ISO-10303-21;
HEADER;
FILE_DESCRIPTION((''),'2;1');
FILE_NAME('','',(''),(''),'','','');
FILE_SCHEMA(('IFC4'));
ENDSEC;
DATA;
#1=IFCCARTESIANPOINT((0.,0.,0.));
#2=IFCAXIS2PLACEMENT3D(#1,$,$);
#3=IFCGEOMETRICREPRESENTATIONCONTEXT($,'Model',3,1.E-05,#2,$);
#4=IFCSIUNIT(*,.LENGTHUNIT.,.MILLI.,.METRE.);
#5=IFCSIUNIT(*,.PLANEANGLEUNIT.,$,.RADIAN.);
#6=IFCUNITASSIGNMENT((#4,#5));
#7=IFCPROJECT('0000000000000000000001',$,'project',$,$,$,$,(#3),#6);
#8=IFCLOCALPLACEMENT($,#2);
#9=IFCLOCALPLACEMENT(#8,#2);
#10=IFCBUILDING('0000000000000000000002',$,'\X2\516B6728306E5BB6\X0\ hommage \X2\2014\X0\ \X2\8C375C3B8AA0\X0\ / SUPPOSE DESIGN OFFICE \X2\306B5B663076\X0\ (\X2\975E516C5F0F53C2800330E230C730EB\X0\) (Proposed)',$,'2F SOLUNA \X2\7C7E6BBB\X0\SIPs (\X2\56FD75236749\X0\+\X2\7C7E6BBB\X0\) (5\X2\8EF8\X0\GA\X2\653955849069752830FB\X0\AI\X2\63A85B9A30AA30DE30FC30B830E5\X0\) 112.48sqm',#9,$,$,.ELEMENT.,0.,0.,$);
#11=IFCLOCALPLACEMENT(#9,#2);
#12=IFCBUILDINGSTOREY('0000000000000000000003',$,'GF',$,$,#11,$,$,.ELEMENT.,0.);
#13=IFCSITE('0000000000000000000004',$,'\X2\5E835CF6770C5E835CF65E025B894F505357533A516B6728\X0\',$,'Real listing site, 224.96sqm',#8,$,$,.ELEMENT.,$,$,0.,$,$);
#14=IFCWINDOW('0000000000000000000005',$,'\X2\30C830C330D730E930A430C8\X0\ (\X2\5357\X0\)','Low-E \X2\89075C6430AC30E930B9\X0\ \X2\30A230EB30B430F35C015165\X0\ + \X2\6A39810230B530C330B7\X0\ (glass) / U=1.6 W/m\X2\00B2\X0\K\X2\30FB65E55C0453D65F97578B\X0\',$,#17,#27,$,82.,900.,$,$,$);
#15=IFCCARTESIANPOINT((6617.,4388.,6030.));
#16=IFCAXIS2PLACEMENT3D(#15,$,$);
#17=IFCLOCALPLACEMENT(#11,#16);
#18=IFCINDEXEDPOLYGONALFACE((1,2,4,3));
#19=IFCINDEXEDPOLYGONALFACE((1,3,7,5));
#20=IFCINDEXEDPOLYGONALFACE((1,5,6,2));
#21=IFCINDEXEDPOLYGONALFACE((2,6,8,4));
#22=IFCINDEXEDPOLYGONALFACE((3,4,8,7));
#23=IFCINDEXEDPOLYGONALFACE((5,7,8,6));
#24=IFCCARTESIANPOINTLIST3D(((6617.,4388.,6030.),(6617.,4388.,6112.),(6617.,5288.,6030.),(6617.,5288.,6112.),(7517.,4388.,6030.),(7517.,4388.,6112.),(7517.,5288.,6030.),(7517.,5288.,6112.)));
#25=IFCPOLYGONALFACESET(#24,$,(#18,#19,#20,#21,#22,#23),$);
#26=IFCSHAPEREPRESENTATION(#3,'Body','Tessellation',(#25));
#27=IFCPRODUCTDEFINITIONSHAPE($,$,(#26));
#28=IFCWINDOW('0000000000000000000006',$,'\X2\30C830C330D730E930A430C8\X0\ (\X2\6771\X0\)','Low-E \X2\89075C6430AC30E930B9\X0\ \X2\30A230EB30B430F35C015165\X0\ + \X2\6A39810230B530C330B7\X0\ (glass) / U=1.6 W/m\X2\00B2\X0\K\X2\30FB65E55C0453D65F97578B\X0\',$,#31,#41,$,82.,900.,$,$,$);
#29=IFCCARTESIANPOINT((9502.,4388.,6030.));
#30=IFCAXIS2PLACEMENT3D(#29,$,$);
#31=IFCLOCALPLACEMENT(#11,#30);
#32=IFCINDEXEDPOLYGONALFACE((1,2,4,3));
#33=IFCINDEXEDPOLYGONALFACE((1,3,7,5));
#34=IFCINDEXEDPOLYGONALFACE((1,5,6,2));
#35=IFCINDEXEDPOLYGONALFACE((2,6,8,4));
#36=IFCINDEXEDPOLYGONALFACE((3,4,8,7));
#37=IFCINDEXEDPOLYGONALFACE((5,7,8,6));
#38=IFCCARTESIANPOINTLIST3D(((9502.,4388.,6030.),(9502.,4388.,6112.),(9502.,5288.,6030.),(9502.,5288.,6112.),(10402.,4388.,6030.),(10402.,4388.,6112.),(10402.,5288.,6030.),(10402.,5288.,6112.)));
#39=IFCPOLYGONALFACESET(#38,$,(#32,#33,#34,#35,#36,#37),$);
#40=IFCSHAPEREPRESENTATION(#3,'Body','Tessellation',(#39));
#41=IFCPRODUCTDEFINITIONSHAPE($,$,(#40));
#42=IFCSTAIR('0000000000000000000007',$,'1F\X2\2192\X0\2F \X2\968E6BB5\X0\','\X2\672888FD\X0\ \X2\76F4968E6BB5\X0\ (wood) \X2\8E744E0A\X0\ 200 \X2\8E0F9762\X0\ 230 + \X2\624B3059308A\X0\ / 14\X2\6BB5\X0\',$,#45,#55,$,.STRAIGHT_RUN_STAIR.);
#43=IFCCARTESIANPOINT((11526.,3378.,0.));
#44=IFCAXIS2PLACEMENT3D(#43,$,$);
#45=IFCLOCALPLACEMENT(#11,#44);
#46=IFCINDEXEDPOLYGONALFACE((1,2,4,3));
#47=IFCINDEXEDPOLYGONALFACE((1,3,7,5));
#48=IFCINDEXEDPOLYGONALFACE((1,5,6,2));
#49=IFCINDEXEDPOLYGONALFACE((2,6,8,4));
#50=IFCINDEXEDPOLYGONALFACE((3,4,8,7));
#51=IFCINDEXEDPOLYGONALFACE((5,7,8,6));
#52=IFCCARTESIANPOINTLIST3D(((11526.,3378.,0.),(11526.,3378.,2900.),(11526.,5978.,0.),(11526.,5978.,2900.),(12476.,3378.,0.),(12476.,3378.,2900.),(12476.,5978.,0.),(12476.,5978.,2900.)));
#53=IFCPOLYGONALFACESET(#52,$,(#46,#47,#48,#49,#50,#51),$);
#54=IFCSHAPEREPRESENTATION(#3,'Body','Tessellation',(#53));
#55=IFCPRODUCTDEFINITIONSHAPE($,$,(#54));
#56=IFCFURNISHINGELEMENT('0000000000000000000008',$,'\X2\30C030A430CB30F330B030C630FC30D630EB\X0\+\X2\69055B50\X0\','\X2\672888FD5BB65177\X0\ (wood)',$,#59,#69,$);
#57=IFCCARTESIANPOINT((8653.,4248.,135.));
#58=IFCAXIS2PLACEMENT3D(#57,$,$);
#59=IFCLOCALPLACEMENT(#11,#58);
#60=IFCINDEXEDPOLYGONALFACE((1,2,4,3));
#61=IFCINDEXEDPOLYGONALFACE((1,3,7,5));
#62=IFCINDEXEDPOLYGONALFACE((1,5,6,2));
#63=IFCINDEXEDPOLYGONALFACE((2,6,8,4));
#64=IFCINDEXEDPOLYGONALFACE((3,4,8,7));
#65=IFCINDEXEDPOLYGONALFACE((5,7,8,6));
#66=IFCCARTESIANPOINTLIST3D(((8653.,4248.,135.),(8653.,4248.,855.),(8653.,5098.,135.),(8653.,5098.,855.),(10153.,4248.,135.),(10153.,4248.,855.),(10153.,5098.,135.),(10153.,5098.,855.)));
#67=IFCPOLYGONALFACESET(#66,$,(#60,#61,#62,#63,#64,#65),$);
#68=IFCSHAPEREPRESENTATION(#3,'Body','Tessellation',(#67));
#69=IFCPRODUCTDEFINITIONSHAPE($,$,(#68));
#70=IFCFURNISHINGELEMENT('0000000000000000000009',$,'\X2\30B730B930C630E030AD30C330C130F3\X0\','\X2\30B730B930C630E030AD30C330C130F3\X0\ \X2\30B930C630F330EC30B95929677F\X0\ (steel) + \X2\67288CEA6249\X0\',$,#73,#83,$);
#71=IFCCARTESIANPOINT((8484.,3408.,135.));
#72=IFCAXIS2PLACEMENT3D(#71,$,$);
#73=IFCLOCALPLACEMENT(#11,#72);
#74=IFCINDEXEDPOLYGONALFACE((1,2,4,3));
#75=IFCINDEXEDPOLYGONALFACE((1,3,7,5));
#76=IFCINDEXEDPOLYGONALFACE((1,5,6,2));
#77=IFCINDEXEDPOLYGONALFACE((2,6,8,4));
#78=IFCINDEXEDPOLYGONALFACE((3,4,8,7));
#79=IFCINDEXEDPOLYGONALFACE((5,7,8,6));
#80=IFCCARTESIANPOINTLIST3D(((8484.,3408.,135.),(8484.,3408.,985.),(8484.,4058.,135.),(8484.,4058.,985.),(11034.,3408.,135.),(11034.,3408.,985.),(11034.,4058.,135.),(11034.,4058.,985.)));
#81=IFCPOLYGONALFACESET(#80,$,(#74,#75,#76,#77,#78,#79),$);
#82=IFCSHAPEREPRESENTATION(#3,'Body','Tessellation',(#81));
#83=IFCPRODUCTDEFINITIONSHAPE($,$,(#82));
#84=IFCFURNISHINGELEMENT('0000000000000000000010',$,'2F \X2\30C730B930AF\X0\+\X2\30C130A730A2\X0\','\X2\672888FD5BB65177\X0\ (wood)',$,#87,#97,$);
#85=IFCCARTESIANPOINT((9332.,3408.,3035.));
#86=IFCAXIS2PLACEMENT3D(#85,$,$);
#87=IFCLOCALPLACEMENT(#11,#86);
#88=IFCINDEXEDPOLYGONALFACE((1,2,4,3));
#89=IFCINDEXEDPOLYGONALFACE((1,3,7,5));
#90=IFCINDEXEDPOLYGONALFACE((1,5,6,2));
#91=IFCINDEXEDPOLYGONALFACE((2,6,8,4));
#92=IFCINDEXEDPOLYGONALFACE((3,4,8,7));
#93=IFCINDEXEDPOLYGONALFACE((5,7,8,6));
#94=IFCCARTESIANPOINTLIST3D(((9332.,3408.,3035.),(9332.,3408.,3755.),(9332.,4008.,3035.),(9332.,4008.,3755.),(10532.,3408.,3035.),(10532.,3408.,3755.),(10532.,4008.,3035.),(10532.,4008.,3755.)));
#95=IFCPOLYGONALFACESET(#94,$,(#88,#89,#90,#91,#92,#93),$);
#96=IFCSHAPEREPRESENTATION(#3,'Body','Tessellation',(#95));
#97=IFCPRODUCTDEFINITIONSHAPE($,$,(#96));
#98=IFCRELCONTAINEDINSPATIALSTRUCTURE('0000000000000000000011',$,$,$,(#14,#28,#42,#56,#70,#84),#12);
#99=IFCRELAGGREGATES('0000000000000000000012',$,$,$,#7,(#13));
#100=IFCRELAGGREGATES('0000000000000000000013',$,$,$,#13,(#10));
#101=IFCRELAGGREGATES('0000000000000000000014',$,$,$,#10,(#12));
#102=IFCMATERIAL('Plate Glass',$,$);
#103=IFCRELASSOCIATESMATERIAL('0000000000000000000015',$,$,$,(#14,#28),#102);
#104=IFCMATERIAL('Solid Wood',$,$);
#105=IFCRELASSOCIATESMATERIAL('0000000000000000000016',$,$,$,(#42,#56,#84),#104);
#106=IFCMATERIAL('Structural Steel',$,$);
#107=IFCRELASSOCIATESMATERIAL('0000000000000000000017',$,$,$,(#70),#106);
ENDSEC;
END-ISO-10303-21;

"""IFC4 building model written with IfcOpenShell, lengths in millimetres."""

from ifc_helpers import new_model, si_unit, frame, frame_2d, origin, place, context, project, spatial, rectangle, extrude, material, element, save


model = new_model("IFC4")

# Units and contexts
model_context = context("Model", 3, precision=1e-05, world=origin())
ifc_project = project(units=[si_unit("LENGTHUNIT", "METRE", prefix="MILLI"), si_unit("PLANEANGLEUNIT", "RADIAN")], contexts=[model_context])

# Site, building, storey
site_placement = place(None, origin())
site = spatial("IfcSite", under=ifc_project, at=site_placement, Name="広島県広島市安佐南区八木", ObjectType="Real listing site, 224.96sqm", CompositionType="ELEMENT", RefElevation=0.0)
building_placement = place(site_placement, origin())
building = spatial("IfcBuilding", under=site, at=building_placement, Name="八木の家 hommage — 谷尻誠 / SUPPOSE DESIGN OFFICE に学ぶ (非公式参考モデル) (Proposed)", ObjectType="2F SOLUNA 籾殻SIPs (国産杉+籾殻) (5軸GA改善適用・AI推定オマージュ) 112.48sqm", CompositionType="ELEMENT", ElevationOfRefHeight=0.0, ElevationOfTerrain=0.0)
storey_placement = place(building_placement, origin())
storey = spatial("IfcBuildingStorey", under=building, at=storey_placement, Name="GF", CompositionType="ELEMENT", Elevation=0.0)

# Shared definitions
ifc_material_1 = material(Name="Solid Wood")

# Shared definitions
ifc_material_2 = material(Name="Plate Glass")

# Windows
window_1_placement = place(storey_placement, frame((6617.0, 4388.0, 6030.0)))
element("IfcWindow", 1, at=window_1_placement, inside=storey, material=ifc_material_2, Name="トップライト (南)", Description="Low-E 複層ガラス アルゴン封入 + 樹脂サッシ (glass) / U=1.6 W/m²K・日射取得型", OverallHeight=82.0, OverallWidth=900.0, context=model_context, shape_type="SweptSolid", body=[
    extrude(rectangle(XDim=900.0, YDim=900.0, at=frame_2d((450.0, 450.0))), frame((6617.0, 4388.0, 6030.0)), (0.0, 0.0, 1.0), 82.0),
])
window_2_placement = place(storey_placement, frame((9502.0, 4388.0, 6030.0)))
element("IfcWindow", 2, at=window_2_placement, inside=storey, material=ifc_material_2, Name="トップライト (東)", Description="Low-E 複層ガラス アルゴン封入 + 樹脂サッシ (glass) / U=1.6 W/m²K・日射取得型", OverallHeight=82.0, OverallWidth=900.0, context=model_context, shape_type="SweptSolid", body=[
    extrude(rectangle(XDim=900.0, YDim=900.0, at=frame_2d((450.0, 450.0))), frame((9502.0, 4388.0, 6030.0)), (0.0, 0.0, 1.0), 82.0),
])

# Stair
stair_placement = place(storey_placement, frame((11526.0, 3378.0, 0.0)))
element("IfcStair", 3, at=stair_placement, inside=storey, material=ifc_material_1, Name="1F→2F 階段", Description="木製 直階段 (wood) 蹴上 200 踏面 230 + 手すり / 14段", PredefinedType="STRAIGHT_RUN_STAIR", context=model_context, shape_type="SweptSolid", body=[
    extrude(rectangle(XDim=950.0, YDim=2600.0, at=frame_2d((475.0, 1300.0))), frame((11526.0, 3378.0, 0.0)), (0.0, 0.0, 1.0), 2900.0),
])

# Furnishing elements
furnishing_1_placement = place(storey_placement, frame((8653.0, 4248.0, 135.0)))
element("IfcFurnishingElement", 4, at=furnishing_1_placement, inside=storey, material=ifc_material_1, Name="ダイニングテーブル+椅子", Description="木製家具 (wood)", context=model_context, shape_type="SweptSolid", body=[
    extrude(rectangle(XDim=1500.0, YDim=850.0, at=frame_2d((750.0, 425.0))), frame((8653.0, 4248.0, 135.0)), (0.0, 0.0, 1.0), 720.0),
])
ifc_material_3 = material(Name="Structural Steel")
furnishing_2_placement = place(storey_placement, frame((8484.0, 3408.0, 135.0)))
element("IfcFurnishingElement", 5, at=furnishing_2_placement, inside=storey, material=ifc_material_3, Name="システムキッチン", Description="システムキッチン ステンレス天板 (steel) + 木質扉", context=model_context, shape_type="SweptSolid", body=[
    extrude(rectangle(XDim=2550.0, YDim=650.0, at=frame_2d((1275.0, 325.0))), frame((8484.0, 3408.0, 135.0)), (0.0, 0.0, 1.0), 850.0),
])
furnishing_3_placement = place(storey_placement, frame((9332.0, 3408.0, 3035.0)))
element("IfcFurnishingElement", 6, at=furnishing_3_placement, inside=storey, material=ifc_material_1, Name="2F デスク+チェア", Description="木製家具 (wood)", context=model_context, shape_type="SweptSolid", body=[
    extrude(rectangle(XDim=1200.0, YDim=600.0, at=frame_2d((600.0, 300.0))), frame((9332.0, 3408.0, 3035.0)), (0.0, 0.0, 1.0), 720.0),
])

save(model, "model.ifc")
